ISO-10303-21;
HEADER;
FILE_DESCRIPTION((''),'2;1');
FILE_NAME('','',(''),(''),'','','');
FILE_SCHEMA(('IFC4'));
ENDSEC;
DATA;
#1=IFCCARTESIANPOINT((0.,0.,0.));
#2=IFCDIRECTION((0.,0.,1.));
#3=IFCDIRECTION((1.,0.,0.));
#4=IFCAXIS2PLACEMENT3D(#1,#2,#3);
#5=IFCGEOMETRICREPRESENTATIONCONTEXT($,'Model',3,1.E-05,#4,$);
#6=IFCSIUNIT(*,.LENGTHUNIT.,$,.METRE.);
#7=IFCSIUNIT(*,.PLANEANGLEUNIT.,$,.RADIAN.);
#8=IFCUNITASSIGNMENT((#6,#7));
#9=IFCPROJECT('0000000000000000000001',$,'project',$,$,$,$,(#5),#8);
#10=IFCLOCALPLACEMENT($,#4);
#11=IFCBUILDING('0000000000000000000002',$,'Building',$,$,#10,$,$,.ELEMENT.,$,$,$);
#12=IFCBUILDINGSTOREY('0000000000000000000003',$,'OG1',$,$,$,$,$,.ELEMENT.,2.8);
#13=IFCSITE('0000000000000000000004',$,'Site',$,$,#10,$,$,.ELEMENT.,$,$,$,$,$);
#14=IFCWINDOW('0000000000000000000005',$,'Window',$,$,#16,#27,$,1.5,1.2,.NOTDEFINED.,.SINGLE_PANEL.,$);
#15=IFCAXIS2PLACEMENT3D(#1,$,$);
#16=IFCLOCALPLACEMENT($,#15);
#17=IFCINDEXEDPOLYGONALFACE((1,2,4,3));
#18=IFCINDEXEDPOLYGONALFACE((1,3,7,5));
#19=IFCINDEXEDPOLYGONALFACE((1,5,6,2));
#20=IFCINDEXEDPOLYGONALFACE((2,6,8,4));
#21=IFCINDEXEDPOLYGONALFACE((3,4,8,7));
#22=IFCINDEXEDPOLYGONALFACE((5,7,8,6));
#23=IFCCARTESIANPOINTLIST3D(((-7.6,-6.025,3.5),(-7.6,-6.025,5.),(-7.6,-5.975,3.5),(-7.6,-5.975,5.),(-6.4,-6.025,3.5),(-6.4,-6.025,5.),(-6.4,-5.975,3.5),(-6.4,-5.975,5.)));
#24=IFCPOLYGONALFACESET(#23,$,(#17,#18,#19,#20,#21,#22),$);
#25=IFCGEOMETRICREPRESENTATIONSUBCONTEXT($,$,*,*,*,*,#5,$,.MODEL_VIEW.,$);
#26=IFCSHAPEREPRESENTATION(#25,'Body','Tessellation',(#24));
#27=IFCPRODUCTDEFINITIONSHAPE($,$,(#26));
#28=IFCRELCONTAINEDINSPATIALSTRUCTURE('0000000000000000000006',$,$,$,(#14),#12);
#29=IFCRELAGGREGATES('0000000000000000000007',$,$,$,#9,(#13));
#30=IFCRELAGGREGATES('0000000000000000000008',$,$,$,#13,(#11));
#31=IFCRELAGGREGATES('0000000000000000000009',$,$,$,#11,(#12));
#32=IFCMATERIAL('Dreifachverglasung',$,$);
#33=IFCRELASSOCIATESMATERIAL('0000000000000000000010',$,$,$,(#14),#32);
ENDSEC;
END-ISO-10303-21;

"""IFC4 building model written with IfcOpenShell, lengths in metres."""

from ifc_helpers import new_model, si_unit, frame, origin, origin_with_axes, origin_2d, place, context, subcontext, project, spatial, rectangle, extrude, material, element, save


model = new_model("IFC4")

# Units and contexts
model_context = context("Model", 3, precision=1e-05, world=origin_with_axes())
sub_context = subcontext(model_context, None, None, "MODEL_VIEW")
ifc_project = project(units=[si_unit("LENGTHUNIT", "METRE"), si_unit("PLANEANGLEUNIT", "RADIAN")], contexts=[model_context])

# Site, building, storey
placement_1 = place(None, origin_with_axes())
site = spatial("IfcSite", under=ifc_project, at=placement_1, Name="Site", CompositionType="ELEMENT")
building = spatial("IfcBuilding", under=site, at=placement_1, Name="Building", CompositionType="ELEMENT")
storey = spatial("IfcBuildingStorey", under=building, Name="OG1", CompositionType="ELEMENT", Elevation=2.8)

# Window
ifc_material = material(Name="Dreifachverglasung")
placement_2 = place(None, origin_with_axes())
window_placement = place(placement_2, frame((-7.0, -6.0, 3.5)))
element("IfcWindow", 1, at=window_placement, inside=storey, material=ifc_material, Name="Window", OverallHeight=1.5, OverallWidth=1.2, PartitioningType="SINGLE_PANEL", PredefinedType="NOTDEFINED", context=sub_context, shape_type="SweptSolid", body=[
    extrude(rectangle(XDim=1.2, YDim=0.05, at=origin_2d()), origin(), (0.0, 0.0, 1.0), 1.5),
])

save(model, "model.ifc")
